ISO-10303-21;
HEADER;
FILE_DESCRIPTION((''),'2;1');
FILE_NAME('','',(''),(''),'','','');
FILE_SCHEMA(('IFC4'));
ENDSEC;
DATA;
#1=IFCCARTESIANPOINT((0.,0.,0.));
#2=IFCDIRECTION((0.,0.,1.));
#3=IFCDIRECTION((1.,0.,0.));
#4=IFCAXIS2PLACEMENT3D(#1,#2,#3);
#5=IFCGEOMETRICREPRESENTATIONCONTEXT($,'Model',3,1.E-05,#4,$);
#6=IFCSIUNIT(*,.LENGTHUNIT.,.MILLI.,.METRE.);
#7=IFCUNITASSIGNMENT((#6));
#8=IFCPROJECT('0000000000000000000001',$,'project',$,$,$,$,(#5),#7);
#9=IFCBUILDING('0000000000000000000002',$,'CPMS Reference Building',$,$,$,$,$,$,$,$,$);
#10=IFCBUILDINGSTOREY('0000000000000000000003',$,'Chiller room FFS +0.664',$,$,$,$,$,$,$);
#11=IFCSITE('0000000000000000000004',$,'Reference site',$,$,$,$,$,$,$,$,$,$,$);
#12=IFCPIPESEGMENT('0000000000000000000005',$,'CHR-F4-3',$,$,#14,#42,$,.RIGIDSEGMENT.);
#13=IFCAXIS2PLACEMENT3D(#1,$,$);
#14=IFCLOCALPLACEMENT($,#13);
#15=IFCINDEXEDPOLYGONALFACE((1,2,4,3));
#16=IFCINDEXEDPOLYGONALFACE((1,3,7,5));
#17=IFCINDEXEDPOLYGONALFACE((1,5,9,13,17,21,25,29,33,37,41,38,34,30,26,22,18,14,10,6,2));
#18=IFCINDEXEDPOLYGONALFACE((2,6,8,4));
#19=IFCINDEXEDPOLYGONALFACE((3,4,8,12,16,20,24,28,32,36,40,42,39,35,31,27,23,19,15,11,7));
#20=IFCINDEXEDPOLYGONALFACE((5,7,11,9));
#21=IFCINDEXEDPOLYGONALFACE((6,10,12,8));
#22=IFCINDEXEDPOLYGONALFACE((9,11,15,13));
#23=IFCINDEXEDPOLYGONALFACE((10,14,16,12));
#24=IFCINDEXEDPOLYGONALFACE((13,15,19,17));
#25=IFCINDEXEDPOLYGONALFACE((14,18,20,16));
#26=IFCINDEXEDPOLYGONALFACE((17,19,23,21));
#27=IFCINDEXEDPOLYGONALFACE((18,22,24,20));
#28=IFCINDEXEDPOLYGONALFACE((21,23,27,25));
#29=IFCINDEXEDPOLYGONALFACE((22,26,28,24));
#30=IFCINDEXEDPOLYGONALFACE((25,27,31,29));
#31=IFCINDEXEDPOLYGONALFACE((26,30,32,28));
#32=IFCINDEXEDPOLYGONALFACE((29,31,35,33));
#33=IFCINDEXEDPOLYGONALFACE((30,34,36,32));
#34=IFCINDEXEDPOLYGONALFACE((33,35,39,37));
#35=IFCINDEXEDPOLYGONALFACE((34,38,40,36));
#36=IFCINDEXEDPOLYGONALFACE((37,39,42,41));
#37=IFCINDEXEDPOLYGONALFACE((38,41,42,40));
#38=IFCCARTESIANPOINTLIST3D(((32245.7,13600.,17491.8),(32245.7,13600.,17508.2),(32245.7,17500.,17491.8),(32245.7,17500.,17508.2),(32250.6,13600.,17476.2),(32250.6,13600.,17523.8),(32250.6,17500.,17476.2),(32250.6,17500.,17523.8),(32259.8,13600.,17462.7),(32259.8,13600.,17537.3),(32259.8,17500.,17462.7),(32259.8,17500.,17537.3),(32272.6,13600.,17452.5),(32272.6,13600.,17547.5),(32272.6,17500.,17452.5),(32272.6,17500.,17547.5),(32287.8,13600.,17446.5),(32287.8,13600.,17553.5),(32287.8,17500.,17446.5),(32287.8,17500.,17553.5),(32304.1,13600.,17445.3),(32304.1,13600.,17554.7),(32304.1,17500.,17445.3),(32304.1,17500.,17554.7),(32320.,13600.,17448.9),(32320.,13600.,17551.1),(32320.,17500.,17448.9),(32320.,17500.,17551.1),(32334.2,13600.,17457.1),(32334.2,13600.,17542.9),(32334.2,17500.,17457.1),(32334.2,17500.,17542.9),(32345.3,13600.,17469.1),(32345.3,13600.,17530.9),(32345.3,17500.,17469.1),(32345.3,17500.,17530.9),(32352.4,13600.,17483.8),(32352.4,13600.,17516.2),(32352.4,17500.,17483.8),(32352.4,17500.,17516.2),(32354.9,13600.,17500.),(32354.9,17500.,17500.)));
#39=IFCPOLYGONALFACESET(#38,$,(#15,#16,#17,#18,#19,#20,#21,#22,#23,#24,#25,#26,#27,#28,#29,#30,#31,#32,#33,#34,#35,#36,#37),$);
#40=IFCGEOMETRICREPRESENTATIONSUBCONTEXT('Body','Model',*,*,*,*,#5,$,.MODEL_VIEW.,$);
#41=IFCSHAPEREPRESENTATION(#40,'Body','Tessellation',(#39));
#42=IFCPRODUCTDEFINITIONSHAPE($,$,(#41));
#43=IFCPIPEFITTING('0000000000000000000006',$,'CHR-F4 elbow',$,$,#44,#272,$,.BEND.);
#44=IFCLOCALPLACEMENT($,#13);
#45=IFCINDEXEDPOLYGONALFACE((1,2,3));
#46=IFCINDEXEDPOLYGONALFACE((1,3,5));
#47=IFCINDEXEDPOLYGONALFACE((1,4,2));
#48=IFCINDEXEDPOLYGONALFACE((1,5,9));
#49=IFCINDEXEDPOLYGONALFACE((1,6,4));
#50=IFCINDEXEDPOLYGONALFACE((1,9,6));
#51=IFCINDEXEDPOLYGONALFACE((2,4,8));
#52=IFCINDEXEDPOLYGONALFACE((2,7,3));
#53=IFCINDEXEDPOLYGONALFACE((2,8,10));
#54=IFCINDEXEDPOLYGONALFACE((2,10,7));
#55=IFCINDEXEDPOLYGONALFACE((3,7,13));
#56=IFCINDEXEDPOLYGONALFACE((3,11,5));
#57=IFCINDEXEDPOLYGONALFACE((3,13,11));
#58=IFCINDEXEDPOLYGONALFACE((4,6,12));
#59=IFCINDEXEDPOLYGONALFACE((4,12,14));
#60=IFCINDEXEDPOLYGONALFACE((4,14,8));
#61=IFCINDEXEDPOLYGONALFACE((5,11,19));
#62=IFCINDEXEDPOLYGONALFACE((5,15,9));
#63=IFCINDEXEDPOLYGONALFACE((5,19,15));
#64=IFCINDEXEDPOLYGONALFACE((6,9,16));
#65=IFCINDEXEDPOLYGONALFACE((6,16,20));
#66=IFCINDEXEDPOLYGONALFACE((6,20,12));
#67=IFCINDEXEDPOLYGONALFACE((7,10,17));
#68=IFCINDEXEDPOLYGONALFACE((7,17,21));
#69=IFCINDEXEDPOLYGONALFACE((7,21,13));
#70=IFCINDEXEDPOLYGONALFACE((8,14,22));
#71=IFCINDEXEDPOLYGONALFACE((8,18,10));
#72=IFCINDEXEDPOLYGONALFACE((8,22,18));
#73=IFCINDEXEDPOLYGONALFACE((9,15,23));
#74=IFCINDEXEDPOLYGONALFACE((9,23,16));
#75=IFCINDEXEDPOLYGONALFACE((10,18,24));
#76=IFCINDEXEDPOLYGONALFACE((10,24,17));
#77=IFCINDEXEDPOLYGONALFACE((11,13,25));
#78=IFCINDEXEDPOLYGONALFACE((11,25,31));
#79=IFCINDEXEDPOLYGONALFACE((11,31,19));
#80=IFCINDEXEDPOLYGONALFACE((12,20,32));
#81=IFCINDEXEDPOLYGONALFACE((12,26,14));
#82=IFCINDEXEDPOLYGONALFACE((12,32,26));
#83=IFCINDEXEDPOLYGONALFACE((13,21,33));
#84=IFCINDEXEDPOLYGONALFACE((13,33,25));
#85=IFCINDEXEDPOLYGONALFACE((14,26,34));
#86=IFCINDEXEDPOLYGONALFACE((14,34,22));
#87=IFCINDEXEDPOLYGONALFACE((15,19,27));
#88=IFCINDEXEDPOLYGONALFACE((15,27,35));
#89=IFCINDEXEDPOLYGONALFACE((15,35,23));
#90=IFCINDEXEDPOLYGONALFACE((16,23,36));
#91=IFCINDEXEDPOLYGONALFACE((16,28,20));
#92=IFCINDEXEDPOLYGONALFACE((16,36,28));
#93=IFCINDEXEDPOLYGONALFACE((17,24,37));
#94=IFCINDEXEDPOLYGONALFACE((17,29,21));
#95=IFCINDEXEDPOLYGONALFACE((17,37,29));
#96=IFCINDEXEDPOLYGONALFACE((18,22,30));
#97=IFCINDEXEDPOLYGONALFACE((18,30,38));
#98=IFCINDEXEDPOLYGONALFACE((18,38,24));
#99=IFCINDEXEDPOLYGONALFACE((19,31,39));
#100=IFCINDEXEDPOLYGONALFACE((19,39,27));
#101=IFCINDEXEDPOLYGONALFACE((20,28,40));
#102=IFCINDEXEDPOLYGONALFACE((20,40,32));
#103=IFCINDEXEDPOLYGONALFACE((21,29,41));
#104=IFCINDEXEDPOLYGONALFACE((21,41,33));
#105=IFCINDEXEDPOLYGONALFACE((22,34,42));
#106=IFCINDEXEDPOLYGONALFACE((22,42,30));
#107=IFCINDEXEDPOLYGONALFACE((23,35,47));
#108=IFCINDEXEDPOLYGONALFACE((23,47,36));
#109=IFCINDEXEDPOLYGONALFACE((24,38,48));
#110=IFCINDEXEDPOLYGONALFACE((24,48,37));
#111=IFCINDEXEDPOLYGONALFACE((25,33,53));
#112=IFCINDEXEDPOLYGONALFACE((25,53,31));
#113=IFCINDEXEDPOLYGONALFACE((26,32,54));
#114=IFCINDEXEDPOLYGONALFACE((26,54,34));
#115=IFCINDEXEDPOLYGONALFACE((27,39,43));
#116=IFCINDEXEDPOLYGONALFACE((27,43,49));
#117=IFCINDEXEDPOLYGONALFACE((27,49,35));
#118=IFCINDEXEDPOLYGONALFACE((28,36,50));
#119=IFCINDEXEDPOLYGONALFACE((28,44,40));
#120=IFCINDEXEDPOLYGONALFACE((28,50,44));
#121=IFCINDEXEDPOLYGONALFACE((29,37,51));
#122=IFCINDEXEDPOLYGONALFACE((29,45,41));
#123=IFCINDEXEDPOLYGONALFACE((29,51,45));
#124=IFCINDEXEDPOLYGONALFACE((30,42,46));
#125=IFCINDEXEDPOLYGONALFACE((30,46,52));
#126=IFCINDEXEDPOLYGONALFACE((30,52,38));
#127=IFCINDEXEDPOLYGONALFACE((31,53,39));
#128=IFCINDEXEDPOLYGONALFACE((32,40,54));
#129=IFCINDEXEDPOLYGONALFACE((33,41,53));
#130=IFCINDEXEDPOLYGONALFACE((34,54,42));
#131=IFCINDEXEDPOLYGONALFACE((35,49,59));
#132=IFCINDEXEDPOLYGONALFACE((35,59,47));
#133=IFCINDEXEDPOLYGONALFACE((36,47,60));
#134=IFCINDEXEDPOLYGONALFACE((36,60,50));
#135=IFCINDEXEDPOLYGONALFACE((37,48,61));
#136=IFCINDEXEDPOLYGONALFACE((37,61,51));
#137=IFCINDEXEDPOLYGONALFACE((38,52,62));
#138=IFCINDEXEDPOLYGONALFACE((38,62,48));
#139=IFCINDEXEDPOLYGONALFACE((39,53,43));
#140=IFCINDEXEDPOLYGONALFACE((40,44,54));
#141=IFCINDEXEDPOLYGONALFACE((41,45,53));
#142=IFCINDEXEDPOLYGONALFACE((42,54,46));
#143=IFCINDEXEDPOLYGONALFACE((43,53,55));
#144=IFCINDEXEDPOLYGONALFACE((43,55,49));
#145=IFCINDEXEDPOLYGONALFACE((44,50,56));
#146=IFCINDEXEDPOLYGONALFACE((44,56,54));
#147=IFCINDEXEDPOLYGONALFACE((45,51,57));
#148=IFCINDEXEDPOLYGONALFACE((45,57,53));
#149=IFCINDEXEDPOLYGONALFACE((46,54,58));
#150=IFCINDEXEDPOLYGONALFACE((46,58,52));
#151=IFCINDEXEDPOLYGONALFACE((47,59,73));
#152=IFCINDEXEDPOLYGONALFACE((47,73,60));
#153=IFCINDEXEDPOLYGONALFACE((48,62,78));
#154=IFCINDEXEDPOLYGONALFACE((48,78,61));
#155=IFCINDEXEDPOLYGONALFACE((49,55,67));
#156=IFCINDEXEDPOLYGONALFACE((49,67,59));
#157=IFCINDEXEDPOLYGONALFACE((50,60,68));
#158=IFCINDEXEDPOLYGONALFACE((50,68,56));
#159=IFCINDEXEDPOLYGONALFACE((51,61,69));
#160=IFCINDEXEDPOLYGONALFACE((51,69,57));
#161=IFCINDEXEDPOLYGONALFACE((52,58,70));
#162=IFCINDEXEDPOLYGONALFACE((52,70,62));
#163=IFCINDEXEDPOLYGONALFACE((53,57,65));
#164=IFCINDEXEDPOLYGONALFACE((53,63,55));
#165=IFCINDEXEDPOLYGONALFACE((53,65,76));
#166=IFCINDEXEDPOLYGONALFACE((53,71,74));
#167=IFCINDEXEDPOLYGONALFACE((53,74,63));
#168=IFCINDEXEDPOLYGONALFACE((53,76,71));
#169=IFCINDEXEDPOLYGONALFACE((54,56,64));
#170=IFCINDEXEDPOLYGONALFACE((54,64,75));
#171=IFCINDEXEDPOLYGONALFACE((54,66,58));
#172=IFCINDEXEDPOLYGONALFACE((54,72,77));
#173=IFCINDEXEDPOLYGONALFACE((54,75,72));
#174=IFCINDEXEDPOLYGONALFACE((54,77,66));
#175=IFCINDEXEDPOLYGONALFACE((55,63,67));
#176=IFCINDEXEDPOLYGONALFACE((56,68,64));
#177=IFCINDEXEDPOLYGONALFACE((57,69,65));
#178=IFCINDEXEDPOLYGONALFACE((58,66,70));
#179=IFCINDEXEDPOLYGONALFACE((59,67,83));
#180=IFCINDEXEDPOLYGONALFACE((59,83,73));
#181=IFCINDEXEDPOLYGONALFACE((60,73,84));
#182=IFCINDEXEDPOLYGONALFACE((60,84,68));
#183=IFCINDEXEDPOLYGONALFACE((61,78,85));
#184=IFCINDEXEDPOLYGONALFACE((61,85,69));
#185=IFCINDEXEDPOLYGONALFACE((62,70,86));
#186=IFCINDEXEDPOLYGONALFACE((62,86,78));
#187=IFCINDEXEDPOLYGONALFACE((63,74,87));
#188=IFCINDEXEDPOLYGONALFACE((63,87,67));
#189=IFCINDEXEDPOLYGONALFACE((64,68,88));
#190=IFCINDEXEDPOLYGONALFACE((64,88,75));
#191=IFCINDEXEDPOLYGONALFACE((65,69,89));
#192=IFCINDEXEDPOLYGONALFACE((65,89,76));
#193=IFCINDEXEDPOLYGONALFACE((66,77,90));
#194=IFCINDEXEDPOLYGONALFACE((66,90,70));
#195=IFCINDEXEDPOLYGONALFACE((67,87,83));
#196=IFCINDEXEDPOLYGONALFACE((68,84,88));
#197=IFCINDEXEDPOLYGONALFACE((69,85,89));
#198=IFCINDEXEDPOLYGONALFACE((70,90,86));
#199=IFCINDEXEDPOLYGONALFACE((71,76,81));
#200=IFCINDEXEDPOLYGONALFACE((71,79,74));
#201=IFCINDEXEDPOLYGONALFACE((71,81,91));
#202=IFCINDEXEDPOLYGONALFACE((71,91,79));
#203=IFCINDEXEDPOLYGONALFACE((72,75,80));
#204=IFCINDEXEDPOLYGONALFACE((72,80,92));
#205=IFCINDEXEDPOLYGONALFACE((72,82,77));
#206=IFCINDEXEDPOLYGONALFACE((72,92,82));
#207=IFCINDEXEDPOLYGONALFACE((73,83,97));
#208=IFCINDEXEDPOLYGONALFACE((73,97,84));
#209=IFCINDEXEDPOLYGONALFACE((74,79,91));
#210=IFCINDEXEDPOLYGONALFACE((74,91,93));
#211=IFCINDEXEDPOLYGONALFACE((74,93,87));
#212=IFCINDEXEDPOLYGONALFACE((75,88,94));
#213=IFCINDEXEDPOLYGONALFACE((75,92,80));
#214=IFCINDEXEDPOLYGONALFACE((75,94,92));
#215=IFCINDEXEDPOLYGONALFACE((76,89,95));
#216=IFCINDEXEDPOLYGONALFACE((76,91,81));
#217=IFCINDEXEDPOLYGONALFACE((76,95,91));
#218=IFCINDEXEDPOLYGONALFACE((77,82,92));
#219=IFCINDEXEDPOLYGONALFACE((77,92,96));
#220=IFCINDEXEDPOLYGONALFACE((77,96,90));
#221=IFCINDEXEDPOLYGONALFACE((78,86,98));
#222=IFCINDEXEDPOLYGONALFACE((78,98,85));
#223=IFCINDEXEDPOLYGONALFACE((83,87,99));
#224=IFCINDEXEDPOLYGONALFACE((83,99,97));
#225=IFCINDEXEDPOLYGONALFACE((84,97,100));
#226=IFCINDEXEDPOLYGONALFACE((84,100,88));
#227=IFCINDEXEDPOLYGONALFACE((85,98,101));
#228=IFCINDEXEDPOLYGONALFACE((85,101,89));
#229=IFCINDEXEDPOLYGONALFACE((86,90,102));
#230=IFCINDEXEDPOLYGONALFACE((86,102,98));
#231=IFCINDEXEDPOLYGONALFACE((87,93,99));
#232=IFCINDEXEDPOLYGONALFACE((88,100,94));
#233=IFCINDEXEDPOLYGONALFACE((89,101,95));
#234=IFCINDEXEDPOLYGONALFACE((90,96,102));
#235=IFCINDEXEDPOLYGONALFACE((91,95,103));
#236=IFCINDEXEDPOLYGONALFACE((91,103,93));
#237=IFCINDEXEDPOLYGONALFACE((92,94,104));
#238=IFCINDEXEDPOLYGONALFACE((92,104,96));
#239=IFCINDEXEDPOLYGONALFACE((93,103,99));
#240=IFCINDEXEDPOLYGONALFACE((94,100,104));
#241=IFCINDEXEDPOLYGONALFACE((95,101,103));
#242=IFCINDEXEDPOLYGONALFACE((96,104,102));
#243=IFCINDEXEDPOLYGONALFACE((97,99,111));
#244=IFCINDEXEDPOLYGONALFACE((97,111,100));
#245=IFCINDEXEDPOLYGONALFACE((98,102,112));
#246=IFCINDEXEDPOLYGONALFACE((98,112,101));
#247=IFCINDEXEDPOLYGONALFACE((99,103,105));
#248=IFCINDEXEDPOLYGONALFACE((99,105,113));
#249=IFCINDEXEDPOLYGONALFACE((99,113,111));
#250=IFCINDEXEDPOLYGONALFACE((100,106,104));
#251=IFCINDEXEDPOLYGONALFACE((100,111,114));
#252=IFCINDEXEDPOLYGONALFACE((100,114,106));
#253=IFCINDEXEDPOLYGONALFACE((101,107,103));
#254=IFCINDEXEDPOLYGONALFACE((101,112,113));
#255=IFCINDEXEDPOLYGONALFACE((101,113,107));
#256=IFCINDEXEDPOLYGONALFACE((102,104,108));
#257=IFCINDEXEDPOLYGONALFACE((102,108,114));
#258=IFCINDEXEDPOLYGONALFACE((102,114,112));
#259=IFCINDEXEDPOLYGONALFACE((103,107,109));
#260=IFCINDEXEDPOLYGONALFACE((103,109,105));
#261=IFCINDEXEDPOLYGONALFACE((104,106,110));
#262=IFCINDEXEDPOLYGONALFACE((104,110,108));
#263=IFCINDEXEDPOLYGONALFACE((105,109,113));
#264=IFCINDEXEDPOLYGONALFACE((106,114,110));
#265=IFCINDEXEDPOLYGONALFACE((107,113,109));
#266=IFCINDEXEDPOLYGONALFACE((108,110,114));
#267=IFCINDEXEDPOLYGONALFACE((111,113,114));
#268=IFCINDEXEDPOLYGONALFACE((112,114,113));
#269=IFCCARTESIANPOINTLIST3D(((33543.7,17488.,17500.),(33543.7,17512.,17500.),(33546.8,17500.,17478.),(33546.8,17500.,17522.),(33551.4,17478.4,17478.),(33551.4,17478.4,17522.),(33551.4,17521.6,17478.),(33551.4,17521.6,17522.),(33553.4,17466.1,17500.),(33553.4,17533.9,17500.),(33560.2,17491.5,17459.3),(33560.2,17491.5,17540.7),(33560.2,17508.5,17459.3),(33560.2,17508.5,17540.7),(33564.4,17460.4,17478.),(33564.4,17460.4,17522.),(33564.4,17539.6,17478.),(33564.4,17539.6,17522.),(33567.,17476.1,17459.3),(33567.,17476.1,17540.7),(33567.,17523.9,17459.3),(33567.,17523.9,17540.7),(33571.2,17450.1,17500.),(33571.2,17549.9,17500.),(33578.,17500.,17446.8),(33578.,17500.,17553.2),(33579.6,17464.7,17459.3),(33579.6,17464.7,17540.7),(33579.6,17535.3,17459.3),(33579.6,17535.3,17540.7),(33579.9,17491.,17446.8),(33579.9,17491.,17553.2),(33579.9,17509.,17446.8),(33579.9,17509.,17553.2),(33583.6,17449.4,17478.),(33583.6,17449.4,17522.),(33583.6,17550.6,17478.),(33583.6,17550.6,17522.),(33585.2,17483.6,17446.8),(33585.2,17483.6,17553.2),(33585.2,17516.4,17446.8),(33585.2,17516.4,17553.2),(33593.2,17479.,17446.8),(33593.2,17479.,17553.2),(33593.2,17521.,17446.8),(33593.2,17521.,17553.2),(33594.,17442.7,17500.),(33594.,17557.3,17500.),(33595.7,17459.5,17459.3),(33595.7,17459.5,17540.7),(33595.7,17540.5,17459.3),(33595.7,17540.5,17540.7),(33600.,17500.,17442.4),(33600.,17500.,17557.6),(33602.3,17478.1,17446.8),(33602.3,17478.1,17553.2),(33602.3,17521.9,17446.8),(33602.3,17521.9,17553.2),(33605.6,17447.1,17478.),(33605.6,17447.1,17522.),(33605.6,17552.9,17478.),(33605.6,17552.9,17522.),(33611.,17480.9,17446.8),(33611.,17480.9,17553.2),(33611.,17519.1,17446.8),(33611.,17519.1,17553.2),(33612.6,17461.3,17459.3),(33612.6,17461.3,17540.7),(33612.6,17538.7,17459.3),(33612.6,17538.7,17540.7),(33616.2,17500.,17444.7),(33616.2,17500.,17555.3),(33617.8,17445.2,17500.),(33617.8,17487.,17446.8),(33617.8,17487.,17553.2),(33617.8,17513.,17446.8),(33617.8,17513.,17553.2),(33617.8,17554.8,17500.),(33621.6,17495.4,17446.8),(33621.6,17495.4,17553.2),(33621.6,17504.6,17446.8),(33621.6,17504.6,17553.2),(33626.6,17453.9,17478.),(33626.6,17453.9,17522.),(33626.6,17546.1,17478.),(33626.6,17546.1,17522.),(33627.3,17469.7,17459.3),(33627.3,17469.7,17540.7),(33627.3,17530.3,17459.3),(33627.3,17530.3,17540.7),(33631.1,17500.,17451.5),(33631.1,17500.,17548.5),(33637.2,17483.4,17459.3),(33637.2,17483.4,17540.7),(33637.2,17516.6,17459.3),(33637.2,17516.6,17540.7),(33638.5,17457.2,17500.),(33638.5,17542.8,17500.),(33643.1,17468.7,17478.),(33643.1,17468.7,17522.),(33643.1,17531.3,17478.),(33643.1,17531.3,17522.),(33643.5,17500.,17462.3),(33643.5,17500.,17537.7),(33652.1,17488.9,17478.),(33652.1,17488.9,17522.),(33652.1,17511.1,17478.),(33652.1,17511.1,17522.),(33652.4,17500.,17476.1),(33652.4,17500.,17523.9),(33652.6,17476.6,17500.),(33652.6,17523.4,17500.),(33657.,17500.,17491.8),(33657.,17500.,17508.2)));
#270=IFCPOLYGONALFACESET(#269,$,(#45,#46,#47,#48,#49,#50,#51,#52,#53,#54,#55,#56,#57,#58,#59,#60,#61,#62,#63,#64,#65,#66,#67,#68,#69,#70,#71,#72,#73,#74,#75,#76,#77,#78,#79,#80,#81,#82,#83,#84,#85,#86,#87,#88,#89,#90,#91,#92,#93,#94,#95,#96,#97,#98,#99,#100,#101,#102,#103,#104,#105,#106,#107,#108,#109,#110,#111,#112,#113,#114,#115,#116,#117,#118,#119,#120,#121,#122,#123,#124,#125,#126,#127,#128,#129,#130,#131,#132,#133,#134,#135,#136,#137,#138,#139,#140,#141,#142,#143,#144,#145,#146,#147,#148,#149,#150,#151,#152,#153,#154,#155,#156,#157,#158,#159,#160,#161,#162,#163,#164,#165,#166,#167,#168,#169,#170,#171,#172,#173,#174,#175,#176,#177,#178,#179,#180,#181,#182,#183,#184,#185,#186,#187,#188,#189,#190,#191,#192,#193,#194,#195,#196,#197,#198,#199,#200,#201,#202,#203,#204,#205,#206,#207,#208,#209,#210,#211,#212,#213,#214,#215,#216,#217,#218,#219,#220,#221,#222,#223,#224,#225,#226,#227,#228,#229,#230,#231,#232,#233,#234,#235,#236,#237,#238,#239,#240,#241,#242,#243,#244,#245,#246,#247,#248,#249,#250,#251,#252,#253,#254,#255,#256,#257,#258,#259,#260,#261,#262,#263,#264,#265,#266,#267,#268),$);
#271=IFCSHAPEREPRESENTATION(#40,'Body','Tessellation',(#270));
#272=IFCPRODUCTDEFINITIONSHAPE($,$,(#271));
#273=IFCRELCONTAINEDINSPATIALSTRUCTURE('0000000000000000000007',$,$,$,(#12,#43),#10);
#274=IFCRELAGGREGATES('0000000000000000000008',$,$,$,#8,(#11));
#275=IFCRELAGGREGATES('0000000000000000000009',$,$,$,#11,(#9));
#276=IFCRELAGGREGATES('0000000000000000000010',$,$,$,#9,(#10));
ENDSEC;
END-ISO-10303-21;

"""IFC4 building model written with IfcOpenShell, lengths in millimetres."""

from ifc_helpers import new_model, entity, si_unit, frame, origin_with_axes, origin_2d, place, context, subcontext, project, spatial, circle_curve, outline, extrude, element, save


model = new_model("IFC4")

# Units and contexts
model_context = context("Model", 3, precision=1e-05, world=origin_with_axes())
body_context = subcontext(model_context, "Body", "Model", "MODEL_VIEW")
ifc_project = project(units=[si_unit("LENGTHUNIT", "METRE", prefix="MILLI")], contexts=[model_context])

# Site, building, storey
site = spatial("IfcSite", under=ifc_project, Name="Reference site")
building = spatial("IfcBuilding", under=site, Name="CPMS Reference Building")
storey = spatial("IfcBuildingStorey", under=building, Name="Chiller room FFS +0.664")

# Pipe segment
pipe_segment_1_placement = place(None, origin_with_axes())
element("IfcPipeSegment", 1, at=pipe_segment_1_placement, inside=storey, Name="CHR-F4-3", PredefinedType="RIGIDSEGMENT", context=body_context, shape_type="SweptSolid", body=[
    extrude(outline(circle_curve(origin_2d(), 54.9)), frame((32300.0, 17500.0, 17500.0), z_axis=(0.0, -1.0, 0.0), x_axis=(1.0, 0.0, 0.0)), (0.0, 0.0, 1.0), 3900.0),
])

# Pipe fitting
pipe_fitting_1_placement = place(None, origin_with_axes())
element("IfcPipeFitting", 2, at=pipe_fitting_1_placement, inside=storey, Name="CHR-F4 elbow", PredefinedType="BEND", context=body_context, shape_type="CSG", body=[
    entity("IfcSphere", entity("IfcAxis2Placement3D", entity("IfcCartesianPoint", [33600.0, 17500.0, 17500.0]), entity("IfcDirection", [0.0, 0.0, 1.0]), entity("IfcDirection", [1.0, 0.0, 0.0])), 57.6),
])

save(model, "model.ifc")
